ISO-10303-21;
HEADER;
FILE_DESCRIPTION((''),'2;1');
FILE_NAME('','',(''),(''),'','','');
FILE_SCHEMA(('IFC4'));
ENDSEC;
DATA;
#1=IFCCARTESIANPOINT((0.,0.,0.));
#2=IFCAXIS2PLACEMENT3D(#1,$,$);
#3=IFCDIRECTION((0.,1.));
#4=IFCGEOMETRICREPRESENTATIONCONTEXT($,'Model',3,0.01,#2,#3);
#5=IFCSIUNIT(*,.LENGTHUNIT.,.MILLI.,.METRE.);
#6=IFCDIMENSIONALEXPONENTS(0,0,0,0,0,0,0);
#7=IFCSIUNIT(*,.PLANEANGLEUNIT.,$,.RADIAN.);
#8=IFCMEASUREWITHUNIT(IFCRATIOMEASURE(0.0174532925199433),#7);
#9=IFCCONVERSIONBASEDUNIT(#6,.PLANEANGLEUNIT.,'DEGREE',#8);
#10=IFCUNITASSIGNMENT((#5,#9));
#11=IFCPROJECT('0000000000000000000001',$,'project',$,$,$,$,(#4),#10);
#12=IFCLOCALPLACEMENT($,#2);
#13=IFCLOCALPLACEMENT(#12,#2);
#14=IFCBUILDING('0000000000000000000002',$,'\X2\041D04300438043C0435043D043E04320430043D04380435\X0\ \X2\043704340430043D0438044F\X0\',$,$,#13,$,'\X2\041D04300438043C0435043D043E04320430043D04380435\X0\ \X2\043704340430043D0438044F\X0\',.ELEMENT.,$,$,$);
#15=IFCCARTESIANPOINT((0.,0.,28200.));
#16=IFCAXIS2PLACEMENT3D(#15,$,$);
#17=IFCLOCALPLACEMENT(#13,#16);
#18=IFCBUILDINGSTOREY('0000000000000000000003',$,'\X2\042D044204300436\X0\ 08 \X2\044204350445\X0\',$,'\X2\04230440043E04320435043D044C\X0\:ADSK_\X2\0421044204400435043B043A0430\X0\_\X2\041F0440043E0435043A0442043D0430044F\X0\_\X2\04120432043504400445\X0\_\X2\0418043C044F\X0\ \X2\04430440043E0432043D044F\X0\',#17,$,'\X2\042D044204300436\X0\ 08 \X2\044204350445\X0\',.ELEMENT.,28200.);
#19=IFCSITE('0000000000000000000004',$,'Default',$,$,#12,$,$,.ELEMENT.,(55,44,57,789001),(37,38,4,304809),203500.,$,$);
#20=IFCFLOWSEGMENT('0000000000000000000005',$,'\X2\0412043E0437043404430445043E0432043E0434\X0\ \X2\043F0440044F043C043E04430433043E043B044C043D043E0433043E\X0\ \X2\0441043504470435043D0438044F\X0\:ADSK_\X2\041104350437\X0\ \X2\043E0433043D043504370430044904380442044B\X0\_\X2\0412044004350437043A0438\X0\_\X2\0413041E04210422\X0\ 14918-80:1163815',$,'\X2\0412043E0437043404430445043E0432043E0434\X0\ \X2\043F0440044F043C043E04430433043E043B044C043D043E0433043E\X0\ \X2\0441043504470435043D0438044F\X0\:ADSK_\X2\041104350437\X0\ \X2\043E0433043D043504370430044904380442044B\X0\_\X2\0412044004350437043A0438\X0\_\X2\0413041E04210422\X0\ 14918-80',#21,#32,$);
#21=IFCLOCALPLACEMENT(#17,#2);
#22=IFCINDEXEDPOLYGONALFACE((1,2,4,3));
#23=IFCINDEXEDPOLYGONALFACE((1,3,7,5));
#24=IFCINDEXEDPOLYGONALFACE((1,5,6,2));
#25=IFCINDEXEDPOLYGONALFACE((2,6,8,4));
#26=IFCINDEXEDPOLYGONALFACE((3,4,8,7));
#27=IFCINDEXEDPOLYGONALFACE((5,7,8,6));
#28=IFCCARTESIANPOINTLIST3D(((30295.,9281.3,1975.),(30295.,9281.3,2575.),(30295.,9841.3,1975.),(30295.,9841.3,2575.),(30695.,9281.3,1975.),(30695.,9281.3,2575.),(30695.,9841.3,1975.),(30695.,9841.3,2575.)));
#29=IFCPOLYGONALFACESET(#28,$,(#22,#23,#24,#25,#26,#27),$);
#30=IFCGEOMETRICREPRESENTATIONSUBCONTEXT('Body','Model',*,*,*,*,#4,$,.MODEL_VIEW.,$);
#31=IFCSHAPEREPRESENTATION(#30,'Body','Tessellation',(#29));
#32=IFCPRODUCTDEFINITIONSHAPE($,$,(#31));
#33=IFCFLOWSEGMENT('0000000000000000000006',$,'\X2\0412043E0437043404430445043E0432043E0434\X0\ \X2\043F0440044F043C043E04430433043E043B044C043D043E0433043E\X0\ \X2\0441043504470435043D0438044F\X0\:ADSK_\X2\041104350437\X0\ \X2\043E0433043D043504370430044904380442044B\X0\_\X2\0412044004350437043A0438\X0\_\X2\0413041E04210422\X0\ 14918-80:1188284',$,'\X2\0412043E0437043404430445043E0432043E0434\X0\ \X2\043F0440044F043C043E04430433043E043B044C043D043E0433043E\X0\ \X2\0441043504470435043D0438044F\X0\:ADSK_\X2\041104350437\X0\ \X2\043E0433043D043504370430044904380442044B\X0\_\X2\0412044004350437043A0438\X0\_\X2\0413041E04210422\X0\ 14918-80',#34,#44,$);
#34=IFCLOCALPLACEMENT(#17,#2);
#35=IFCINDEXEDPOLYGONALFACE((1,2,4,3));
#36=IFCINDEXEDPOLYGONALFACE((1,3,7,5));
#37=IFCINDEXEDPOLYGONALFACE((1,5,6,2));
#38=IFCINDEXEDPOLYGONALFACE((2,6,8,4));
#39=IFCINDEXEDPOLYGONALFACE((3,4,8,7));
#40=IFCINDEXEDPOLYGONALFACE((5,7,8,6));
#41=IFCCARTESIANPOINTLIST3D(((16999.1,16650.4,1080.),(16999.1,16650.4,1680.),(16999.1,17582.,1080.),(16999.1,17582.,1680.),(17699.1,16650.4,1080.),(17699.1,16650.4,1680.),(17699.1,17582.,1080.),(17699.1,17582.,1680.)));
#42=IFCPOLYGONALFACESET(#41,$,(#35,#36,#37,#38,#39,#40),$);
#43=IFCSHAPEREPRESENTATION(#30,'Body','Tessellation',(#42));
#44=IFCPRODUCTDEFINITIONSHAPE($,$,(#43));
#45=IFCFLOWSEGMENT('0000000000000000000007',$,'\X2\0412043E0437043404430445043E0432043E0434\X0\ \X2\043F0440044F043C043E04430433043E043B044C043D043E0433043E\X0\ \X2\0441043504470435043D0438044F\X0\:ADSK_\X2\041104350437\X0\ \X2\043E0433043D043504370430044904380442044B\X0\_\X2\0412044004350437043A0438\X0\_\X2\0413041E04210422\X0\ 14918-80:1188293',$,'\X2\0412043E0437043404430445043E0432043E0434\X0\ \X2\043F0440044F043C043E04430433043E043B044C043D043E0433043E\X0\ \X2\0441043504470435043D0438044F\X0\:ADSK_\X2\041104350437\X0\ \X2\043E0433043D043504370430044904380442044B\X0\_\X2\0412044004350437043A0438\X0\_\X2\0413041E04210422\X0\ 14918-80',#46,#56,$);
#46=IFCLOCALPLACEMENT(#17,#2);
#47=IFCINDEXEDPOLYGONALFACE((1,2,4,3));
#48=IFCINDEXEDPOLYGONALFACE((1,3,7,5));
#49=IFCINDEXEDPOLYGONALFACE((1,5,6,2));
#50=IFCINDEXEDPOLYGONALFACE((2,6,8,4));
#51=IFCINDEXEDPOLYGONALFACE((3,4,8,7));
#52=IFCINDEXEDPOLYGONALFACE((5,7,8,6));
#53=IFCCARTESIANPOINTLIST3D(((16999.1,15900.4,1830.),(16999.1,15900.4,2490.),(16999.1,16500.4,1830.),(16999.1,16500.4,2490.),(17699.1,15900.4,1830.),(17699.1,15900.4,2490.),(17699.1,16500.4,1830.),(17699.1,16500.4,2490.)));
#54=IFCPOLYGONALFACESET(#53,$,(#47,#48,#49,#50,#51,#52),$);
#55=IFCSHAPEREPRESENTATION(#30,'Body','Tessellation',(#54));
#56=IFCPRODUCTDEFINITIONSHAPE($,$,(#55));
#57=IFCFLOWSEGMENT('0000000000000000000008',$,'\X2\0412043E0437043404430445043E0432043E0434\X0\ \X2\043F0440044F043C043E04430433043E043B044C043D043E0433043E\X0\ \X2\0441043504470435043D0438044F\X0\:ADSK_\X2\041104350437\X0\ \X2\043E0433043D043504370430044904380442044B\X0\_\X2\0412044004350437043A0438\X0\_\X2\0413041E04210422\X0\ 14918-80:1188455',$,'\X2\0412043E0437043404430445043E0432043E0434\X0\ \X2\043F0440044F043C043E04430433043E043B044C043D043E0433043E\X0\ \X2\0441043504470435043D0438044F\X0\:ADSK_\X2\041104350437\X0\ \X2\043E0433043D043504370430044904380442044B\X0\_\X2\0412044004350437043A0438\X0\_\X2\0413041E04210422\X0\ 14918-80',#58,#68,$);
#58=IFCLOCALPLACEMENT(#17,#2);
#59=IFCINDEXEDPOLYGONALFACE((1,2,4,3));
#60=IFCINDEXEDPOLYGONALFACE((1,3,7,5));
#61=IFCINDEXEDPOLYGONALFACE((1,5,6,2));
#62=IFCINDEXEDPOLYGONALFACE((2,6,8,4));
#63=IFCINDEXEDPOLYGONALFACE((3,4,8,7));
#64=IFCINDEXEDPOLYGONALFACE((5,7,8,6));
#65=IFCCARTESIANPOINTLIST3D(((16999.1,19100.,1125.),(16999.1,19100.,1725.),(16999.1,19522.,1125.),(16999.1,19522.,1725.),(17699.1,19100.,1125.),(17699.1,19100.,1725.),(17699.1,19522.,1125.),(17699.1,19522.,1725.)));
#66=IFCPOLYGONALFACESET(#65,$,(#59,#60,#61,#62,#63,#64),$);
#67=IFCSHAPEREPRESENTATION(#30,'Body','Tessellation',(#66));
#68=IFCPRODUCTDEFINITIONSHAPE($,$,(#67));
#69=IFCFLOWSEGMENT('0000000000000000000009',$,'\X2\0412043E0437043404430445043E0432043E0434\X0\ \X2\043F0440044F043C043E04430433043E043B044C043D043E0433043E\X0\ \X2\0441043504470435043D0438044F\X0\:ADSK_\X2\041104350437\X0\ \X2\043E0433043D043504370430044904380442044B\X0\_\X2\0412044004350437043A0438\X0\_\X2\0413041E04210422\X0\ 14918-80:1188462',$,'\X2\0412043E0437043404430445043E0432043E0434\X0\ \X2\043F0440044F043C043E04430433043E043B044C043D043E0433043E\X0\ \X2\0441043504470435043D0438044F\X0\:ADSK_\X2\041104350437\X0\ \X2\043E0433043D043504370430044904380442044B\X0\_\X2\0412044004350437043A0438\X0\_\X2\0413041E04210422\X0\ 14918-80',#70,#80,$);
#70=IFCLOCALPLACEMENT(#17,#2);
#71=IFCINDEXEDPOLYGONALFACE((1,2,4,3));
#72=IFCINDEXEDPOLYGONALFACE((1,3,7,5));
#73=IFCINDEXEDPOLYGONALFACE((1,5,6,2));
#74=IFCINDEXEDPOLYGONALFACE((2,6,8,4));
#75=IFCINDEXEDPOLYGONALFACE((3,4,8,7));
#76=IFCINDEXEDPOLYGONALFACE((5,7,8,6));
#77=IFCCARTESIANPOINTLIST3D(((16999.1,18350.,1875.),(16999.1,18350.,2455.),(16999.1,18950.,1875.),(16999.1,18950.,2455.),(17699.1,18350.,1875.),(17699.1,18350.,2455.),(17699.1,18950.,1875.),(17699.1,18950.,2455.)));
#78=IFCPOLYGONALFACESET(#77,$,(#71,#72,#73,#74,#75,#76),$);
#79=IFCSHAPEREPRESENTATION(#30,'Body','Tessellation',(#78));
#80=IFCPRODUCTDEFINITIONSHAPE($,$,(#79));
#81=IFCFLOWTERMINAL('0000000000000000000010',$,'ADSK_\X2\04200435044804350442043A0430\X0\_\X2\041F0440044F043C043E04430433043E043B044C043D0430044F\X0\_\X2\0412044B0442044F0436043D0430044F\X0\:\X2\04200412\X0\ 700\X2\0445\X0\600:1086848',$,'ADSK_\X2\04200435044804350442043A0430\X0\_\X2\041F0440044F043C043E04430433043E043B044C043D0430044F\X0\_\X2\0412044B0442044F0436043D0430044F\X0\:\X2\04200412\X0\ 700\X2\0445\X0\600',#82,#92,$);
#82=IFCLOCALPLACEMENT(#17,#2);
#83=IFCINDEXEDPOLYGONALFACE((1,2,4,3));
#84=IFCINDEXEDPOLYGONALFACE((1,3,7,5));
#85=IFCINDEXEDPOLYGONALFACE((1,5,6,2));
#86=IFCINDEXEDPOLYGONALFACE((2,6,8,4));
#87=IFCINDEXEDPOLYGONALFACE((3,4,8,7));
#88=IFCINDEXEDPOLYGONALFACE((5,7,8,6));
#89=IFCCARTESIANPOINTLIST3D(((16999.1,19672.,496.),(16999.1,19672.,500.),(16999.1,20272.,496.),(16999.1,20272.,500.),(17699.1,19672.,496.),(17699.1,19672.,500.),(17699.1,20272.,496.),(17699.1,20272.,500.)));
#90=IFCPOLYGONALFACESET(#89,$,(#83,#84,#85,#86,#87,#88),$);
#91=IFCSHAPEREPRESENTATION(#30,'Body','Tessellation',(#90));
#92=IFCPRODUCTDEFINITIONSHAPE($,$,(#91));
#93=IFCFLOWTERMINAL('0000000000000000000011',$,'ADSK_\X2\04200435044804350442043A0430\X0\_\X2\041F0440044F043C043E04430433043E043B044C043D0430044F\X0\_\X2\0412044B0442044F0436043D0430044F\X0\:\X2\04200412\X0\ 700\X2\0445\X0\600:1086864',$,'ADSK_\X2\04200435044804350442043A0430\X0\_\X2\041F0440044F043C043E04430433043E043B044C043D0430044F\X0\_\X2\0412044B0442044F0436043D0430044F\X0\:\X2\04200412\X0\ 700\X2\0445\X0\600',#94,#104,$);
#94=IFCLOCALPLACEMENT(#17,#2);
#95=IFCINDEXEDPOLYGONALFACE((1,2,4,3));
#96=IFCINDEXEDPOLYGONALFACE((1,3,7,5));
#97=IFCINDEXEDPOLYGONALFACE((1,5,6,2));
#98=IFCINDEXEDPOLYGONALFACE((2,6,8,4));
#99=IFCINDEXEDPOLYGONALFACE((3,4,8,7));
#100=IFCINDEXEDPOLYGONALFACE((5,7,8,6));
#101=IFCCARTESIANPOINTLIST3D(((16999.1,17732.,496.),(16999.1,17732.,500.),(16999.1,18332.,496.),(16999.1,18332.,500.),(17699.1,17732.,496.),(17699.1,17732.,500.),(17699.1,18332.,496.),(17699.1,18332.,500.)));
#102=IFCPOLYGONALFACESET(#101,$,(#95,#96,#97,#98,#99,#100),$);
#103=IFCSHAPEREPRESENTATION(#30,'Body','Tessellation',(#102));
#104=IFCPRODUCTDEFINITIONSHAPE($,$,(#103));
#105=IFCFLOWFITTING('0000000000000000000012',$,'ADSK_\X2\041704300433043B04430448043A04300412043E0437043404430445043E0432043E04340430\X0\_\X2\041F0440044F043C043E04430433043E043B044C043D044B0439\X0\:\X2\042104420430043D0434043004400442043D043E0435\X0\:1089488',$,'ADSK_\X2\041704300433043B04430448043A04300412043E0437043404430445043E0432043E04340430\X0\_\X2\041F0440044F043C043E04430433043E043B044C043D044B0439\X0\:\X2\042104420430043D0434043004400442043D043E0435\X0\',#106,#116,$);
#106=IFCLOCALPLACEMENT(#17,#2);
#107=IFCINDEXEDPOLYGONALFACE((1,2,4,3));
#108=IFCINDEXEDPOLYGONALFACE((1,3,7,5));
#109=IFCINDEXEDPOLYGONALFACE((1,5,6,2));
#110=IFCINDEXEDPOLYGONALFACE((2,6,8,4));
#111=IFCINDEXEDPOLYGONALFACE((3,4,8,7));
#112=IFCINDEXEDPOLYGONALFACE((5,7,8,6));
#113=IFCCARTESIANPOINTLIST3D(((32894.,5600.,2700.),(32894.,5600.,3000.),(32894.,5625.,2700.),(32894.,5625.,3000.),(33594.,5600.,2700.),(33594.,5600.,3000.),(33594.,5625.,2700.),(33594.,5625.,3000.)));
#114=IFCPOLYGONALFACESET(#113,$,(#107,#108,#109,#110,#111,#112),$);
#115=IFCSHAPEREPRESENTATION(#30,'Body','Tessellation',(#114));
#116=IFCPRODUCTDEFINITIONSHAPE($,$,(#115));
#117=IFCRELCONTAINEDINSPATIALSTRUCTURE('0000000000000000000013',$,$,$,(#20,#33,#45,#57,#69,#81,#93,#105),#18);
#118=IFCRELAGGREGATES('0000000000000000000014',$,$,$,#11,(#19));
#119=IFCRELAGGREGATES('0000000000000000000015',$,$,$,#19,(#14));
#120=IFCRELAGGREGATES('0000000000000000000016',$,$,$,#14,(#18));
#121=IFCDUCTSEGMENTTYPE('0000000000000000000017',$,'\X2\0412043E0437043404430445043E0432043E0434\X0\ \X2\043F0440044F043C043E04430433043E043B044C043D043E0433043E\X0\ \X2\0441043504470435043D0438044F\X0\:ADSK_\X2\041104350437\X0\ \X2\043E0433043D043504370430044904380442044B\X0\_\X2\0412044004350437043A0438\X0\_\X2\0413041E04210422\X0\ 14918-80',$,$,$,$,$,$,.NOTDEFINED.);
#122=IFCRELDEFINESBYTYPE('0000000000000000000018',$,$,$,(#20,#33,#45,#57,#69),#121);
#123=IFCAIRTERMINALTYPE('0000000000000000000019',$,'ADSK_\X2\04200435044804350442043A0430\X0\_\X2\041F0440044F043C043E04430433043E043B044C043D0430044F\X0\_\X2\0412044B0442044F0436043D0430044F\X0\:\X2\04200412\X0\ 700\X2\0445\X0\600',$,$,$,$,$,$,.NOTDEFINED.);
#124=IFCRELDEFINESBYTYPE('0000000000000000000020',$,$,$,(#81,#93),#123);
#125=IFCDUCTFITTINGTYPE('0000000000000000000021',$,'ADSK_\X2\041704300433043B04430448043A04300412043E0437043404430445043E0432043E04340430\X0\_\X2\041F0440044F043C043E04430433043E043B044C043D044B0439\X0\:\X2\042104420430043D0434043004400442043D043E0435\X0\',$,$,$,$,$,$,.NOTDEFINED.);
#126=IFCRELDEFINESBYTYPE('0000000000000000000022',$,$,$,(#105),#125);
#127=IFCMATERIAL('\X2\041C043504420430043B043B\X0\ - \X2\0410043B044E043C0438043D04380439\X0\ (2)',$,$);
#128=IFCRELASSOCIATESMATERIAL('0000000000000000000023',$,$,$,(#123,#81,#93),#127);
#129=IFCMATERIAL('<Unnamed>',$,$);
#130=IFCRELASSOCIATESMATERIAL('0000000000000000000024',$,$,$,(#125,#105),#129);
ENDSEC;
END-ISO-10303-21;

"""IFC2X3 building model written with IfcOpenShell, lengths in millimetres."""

from ifc_helpers import new_model, entity, si_unit, converted_unit, direction, frame, frame_2d, origin, origin_2d_with_axis, place, context, subcontext, project, spatial, rectangle, extrude, source, transform, mapped, material, type_object, type_shapes, element, save


model = new_model("IFC2X3")

# Units and contexts
model_context = context("Model", 3, precision=0.01, world=origin(), true_north=direction((0.0, 1.0)))
body_context = subcontext(model_context, "Body", "Model", "MODEL_VIEW")
ifc_project = project(units=[si_unit("LENGTHUNIT", "METRE", prefix="MILLI"), converted_unit("PLANEANGLEUNIT", "DEGREE", entity("IfcRatioMeasure", 0.0174532925199433), si_unit("PLANEANGLEUNIT", "RADIAN"), dimensions=[0, 0, 0, 0, 0, 0, 0])], contexts=[model_context])

# Site, building, storey
site_placement = place(None, frame((0.0, 0.0, 0.0)))
site = spatial("IfcSite", under=ifc_project, at=site_placement, Name="Default", CompositionType="ELEMENT", RefLatitude=(55, 44, 57, 789001), RefLongitude=(37, 38, 4, 304809), RefElevation=203500.0)
building_placement = place(site_placement, origin())
building = spatial("IfcBuilding", under=site, at=building_placement, Name="Наименование здания", LongName="Наименование здания", CompositionType="ELEMENT")
storey_placement = place(building_placement, frame((0.0, 0.0, 28200.0)))
storey = spatial("IfcBuildingStorey", under=building, at=storey_placement, Name="Этаж 08 тех", ObjectType="Уровень:ADSK_Стрелка_Проектная_Вверх_Имя уровня", LongName="Этаж 08 тех", CompositionType="ELEMENT", Elevation=28200.0)

# Shared definitions
ifc_material_1 = material(Name="Металл - Алюминий (2)")

# Shared definitions
ifc_material_2 = material(Name="<Unnamed>")

# Flow segments
duct_segment_type_1 = type_object("IfcDuctSegmentType", Name="Воздуховод прямоугольного сечения:ADSK_Без огнезащиты_Врезки_ГОСТ 14918-80", PredefinedType="NOTDEFINED")
flow_segment_1_placement = place(storey_placement, frame((30295.0, 9281.3, 1975.0)))
element("IfcFlowSegment", 1, at=flow_segment_1_placement, inside=storey, type_object=duct_segment_type_1, Name="Воздуховод прямоугольного сечения:ADSK_Без огнезащиты_Врезки_ГОСТ 14918-80:1163815", ObjectType="Воздуховод прямоугольного сечения:ADSK_Без огнезащиты_Врезки_ГОСТ 14918-80", context=body_context, shape_type="SweptSolid", body=[
    extrude(rectangle(XDim=560.0, YDim=400.0, at=frame_2d((0.0, 0.0), x_axis=(1.0, 0.0))), frame((200.0, 280.0, 0.0), z_axis=(0.0, 0.0, 1.0), x_axis=(0.0, -1.0, 0.0)), (0.0, 0.0, 1.0), 600.0),
])
flow_segment_2_placement = place(storey_placement, frame((16999.1, 16650.4, 1080.0)))
element("IfcFlowSegment", 2, at=flow_segment_2_placement, inside=storey, type_object=duct_segment_type_1, Name="Воздуховод прямоугольного сечения:ADSK_Без огнезащиты_Врезки_ГОСТ 14918-80:1188284", ObjectType="Воздуховод прямоугольного сечения:ADSK_Без огнезащиты_Врезки_ГОСТ 14918-80", context=body_context, shape_type="SweptSolid", body=[
    extrude(rectangle(XDim=931.6, YDim=700.0, at=origin_2d_with_axis()), frame((350.0, 465.8, 0.0), z_axis=(0.0, 0.0, 1.0), x_axis=(0.0, -1.0, 0.0)), (0.0, 0.0, 1.0), 600.0),
])
flow_segment_3_placement = place(storey_placement, frame((16999.1, 15900.4, 1830.0)))
element("IfcFlowSegment", 3, at=flow_segment_3_placement, inside=storey, type_object=duct_segment_type_1, Name="Воздуховод прямоугольного сечения:ADSK_Без огнезащиты_Врезки_ГОСТ 14918-80:1188293", ObjectType="Воздуховод прямоугольного сечения:ADSK_Без огнезащиты_Врезки_ГОСТ 14918-80", context=body_context, shape_type="SweptSolid", body=[
    extrude(rectangle(XDim=700.0, YDim=600.0, at=frame_2d((0.0, 0.0), x_axis=(1.0, 0.0))), frame((350.0, 300.0, 0.0)), (0.0, 0.0, 1.0), 660.0),
])
flow_segment_4_placement = place(storey_placement, frame((16999.1, 19100.0, 1125.0)))
element("IfcFlowSegment", 4, at=flow_segment_4_placement, inside=storey, type_object=duct_segment_type_1, Name="Воздуховод прямоугольного сечения:ADSK_Без огнезащиты_Врезки_ГОСТ 14918-80:1188455", ObjectType="Воздуховод прямоугольного сечения:ADSK_Без огнезащиты_Врезки_ГОСТ 14918-80", context=body_context, shape_type="SweptSolid", body=[
    extrude(rectangle(XDim=422.0, YDim=700.0, at=frame_2d((0.0, 0.0), x_axis=(1.0, 0.0))), frame((350.0, 211.0, 0.0), z_axis=(0.0, 0.0, 1.0), x_axis=(0.0, -1.0, 0.0)), (0.0, 0.0, 1.0), 600.0),
])
flow_segment_5_placement = place(storey_placement, frame((16999.1, 18350.0, 1875.0)))
element("IfcFlowSegment", 5, at=flow_segment_5_placement, inside=storey, type_object=duct_segment_type_1, Name="Воздуховод прямоугольного сечения:ADSK_Без огнезащиты_Врезки_ГОСТ 14918-80:1188462", ObjectType="Воздуховод прямоугольного сечения:ADSK_Без огнезащиты_Врезки_ГОСТ 14918-80", context=body_context, shape_type="SweptSolid", body=[
    extrude(rectangle(XDim=700.0, YDim=600.0, at=frame_2d((0.0, 0.0), x_axis=(1.0, 0.0))), frame((350.0, 300.0, 0.0)), (0.0, 0.0, 1.0), 580.0),
])

# Flow terminals
air_terminal_type_1 = type_object("IfcAirTerminalType", Name="ADSK_Решетка_Прямоугольная_Вытяжная:РВ 700х600", PredefinedType="NOTDEFINED", material=ifc_material_1)
shared_shape_1 = source(origin(), body_context, "Body", "SweptSolid", [
    extrude(rectangle(XDim=4.0, YDim=700.0, at=origin_2d_with_axis()), frame((0.0, -2.0, -300.0), z_axis=(0.0, 0.0, 1.0), x_axis=(0.0, 1.0, 0.0)), (0.0, 0.0, 1.0), 600.0),
])
type_shapes(air_terminal_type_1, [shared_shape_1])
for number, where, z_axis, x_axis, name in (
    (6, (17349.1, 19972.0, 500.0), (0.0, -1.0, 0.0), (1.0, 0.0, 0.0), "ADSK_Решетка_Прямоугольная_Вытяжная:РВ 700х600:1086848"),
    (7, (17349.1, 18032.0, 500.0), (0.0, -1.0, 0.0), (1.0, 0.0, 0.0), "ADSK_Решетка_Прямоугольная_Вытяжная:РВ 700х600:1086864"),
):
    element("IfcFlowTerminal", number, at=place(storey_placement, frame(where, z_axis=z_axis, x_axis=x_axis)), inside=storey, type_object=air_terminal_type_1, material=ifc_material_1, Name=name, ObjectType="ADSK_Решетка_Прямоугольная_Вытяжная:РВ 700х600", context=body_context, shape_type="MappedRepresentation", body=[
        mapped(shared_shape_1, transform((0.0, 0.0, 0.0), scale=1.0)),
    ])

# Flow fitting
duct_fitting_type_1 = type_object("IfcDuctFittingType", Name="ADSK_ЗаглушкаВоздуховода_Прямоугольный:Стандартное", PredefinedType="NOTDEFINED", material=ifc_material_2)
shared_shape_2 = source(origin(), body_context, "Body", "SweptSolid", [
    extrude(rectangle(XDim=25.0, YDim=700.0, at=frame_2d((0.0, 0.0), x_axis=(1.0, 0.0))), frame((12.5, 0.0, -150.0)), (0.0, 0.0, 1.0), 300.0),
])
type_shapes(duct_fitting_type_1, [shared_shape_2])
flow_fitting_1_placement = place(storey_placement, frame((33244.0, 5625.0, 2850.0), z_axis=(0.0, 0.0, 1.0), x_axis=(0.0, -1.0, 0.0)))
element("IfcFlowFitting", 8, at=flow_fitting_1_placement, inside=storey, type_object=duct_fitting_type_1, material=ifc_material_2, Name="ADSK_ЗаглушкаВоздуховода_Прямоугольный:Стандартное:1089488", ObjectType="ADSK_ЗаглушкаВоздуховода_Прямоугольный:Стандартное", context=body_context, shape_type="MappedRepresentation", body=[
    mapped(shared_shape_2, transform((0.0, 0.0, 0.0), scale=1.0)),
])

save(model, "model.ifc")
